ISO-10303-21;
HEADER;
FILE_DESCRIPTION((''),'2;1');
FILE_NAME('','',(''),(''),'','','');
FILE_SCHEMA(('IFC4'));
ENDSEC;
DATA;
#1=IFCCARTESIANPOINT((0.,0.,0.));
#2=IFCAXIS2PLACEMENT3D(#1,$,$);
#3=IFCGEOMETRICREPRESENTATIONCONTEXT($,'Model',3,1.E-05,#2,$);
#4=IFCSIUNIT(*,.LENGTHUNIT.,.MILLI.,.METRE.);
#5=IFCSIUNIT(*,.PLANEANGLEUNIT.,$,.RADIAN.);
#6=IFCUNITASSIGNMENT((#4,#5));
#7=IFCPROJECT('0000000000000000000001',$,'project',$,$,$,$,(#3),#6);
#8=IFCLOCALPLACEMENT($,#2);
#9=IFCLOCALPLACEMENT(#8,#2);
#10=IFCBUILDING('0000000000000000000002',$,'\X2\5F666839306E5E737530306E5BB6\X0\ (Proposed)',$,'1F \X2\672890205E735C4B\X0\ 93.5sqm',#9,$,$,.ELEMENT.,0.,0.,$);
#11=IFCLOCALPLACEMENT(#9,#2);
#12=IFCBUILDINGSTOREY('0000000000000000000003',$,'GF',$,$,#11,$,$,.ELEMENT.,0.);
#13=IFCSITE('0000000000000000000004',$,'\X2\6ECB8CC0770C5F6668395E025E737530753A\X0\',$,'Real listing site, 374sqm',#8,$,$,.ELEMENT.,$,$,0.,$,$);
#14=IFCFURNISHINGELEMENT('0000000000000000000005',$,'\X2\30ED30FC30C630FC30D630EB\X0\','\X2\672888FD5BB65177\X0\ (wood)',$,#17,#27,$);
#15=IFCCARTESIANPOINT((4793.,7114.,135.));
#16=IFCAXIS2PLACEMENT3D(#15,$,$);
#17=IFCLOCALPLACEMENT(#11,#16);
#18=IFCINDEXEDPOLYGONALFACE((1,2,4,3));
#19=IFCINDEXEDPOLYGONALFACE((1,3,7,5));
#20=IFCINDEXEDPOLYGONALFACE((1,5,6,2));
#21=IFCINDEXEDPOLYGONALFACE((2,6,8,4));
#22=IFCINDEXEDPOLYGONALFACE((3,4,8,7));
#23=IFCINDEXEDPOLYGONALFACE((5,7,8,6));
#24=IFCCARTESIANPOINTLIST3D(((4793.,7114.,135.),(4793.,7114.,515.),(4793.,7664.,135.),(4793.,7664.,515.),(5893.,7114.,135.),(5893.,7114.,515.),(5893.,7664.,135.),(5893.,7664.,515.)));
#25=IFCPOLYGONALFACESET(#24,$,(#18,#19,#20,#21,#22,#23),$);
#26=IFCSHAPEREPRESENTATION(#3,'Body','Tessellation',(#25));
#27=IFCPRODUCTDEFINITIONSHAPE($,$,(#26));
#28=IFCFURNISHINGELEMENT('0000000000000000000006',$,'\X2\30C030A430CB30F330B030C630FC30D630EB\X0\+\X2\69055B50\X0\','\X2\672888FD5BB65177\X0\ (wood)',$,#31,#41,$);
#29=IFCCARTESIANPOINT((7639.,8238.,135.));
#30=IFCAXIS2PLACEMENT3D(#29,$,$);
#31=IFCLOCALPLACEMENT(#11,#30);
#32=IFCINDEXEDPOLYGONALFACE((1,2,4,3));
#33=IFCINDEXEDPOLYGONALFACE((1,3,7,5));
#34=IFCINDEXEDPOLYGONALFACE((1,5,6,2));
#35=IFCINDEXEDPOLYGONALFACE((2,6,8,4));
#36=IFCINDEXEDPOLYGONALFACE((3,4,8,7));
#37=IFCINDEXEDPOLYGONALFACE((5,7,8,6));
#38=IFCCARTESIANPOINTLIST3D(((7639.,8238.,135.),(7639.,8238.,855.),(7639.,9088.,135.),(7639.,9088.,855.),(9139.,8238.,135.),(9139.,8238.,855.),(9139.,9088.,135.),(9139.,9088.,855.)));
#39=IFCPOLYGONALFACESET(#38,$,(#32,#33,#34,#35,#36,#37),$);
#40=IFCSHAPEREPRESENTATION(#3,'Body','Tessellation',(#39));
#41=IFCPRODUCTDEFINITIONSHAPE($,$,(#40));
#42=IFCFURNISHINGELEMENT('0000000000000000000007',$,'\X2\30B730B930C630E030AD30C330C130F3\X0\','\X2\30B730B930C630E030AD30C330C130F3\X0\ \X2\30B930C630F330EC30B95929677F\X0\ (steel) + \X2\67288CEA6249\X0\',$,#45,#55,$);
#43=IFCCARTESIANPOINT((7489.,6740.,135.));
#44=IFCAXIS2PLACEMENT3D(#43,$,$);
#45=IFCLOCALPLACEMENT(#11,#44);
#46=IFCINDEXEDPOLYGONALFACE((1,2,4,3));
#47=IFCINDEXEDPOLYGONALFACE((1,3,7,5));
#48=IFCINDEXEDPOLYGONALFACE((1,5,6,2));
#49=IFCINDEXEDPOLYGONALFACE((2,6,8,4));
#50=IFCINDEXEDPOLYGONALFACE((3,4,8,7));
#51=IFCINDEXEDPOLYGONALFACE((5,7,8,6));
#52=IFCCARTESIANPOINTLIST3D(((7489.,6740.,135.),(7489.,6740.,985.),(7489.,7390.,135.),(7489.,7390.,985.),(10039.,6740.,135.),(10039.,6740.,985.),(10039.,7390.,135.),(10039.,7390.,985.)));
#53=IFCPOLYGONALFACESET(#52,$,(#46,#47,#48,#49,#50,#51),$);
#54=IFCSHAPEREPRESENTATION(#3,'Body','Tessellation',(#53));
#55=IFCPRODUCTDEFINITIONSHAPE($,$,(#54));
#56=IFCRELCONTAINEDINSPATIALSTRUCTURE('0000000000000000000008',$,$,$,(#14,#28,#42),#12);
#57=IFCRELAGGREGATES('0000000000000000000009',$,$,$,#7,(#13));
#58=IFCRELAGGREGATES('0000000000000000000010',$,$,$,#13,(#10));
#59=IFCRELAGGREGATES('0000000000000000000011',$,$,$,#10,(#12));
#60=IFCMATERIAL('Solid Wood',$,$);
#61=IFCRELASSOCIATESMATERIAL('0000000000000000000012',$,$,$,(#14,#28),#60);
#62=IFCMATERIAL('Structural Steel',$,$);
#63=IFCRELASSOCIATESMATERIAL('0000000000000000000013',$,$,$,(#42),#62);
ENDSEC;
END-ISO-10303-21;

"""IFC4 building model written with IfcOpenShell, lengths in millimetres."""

from ifc_helpers import new_model, si_unit, frame, frame_2d, origin, place, context, project, spatial, rectangle, extrude, material, element, save


model = new_model("IFC4")

# Units and contexts
model_context = context("Model", 3, precision=1e-05, world=origin())
ifc_project = project(units=[si_unit("LENGTHUNIT", "METRE", prefix="MILLI"), si_unit("PLANEANGLEUNIT", "RADIAN")], contexts=[model_context])

# Site, building, storey
site_placement = place(None, origin())
site = spatial("IfcSite", under=ifc_project, at=site_placement, Name="滋賀県彦根市平田町", ObjectType="Real listing site, 374sqm", CompositionType="ELEMENT", RefElevation=0.0)
building_placement = place(site_placement, origin())
building = spatial("IfcBuilding", under=site, at=building_placement, Name="彦根の平田の家 (Proposed)", ObjectType="1F 木造平屋 93.5sqm", CompositionType="ELEMENT", ElevationOfRefHeight=0.0, ElevationOfTerrain=0.0)
storey_placement = place(building_placement, origin())
storey = spatial("IfcBuildingStorey", under=building, at=storey_placement, Name="GF", CompositionType="ELEMENT", Elevation=0.0)

# Shared definitions
ifc_material_1 = material(Name="Solid Wood")

# Shared definitions
ifc_material_2 = material(Name="Structural Steel")

# Furnishing elements
furnishing_1_placement = place(storey_placement, frame((4793.0, 7114.0, 135.0)))
element("IfcFurnishingElement", 1, at=furnishing_1_placement, inside=storey, material=ifc_material_1, Name="ローテーブル", Description="木製家具 (wood)", context=model_context, shape_type="SweptSolid", body=[
    extrude(rectangle(XDim=1100.0, YDim=550.0, at=frame_2d((550.0, 275.0))), frame((4793.0, 7114.0, 135.0)), (0.0, 0.0, 1.0), 380.0),
])
furnishing_2_placement = place(storey_placement, frame((7639.0, 8238.0, 135.0)))
element("IfcFurnishingElement", 2, at=furnishing_2_placement, inside=storey, material=ifc_material_1, Name="ダイニングテーブル+椅子", Description="木製家具 (wood)", context=model_context, shape_type="SweptSolid", body=[
    extrude(rectangle(XDim=1500.0, YDim=850.0, at=frame_2d((750.0, 425.0))), frame((7639.0, 8238.0, 135.0)), (0.0, 0.0, 1.0), 720.0),
])
furnishing_3_placement = place(storey_placement, frame((7489.0, 6740.0, 135.0)))
element("IfcFurnishingElement", 3, at=furnishing_3_placement, inside=storey, material=ifc_material_2, Name="システムキッチン", Description="システムキッチン ステンレス天板 (steel) + 木質扉", context=model_context, shape_type="SweptSolid", body=[
    extrude(rectangle(XDim=2550.0, YDim=650.0, at=frame_2d((1275.0, 325.0))), frame((7489.0, 6740.0, 135.0)), (0.0, 0.0, 1.0), 850.0),
])

save(model, "model.ifc")
